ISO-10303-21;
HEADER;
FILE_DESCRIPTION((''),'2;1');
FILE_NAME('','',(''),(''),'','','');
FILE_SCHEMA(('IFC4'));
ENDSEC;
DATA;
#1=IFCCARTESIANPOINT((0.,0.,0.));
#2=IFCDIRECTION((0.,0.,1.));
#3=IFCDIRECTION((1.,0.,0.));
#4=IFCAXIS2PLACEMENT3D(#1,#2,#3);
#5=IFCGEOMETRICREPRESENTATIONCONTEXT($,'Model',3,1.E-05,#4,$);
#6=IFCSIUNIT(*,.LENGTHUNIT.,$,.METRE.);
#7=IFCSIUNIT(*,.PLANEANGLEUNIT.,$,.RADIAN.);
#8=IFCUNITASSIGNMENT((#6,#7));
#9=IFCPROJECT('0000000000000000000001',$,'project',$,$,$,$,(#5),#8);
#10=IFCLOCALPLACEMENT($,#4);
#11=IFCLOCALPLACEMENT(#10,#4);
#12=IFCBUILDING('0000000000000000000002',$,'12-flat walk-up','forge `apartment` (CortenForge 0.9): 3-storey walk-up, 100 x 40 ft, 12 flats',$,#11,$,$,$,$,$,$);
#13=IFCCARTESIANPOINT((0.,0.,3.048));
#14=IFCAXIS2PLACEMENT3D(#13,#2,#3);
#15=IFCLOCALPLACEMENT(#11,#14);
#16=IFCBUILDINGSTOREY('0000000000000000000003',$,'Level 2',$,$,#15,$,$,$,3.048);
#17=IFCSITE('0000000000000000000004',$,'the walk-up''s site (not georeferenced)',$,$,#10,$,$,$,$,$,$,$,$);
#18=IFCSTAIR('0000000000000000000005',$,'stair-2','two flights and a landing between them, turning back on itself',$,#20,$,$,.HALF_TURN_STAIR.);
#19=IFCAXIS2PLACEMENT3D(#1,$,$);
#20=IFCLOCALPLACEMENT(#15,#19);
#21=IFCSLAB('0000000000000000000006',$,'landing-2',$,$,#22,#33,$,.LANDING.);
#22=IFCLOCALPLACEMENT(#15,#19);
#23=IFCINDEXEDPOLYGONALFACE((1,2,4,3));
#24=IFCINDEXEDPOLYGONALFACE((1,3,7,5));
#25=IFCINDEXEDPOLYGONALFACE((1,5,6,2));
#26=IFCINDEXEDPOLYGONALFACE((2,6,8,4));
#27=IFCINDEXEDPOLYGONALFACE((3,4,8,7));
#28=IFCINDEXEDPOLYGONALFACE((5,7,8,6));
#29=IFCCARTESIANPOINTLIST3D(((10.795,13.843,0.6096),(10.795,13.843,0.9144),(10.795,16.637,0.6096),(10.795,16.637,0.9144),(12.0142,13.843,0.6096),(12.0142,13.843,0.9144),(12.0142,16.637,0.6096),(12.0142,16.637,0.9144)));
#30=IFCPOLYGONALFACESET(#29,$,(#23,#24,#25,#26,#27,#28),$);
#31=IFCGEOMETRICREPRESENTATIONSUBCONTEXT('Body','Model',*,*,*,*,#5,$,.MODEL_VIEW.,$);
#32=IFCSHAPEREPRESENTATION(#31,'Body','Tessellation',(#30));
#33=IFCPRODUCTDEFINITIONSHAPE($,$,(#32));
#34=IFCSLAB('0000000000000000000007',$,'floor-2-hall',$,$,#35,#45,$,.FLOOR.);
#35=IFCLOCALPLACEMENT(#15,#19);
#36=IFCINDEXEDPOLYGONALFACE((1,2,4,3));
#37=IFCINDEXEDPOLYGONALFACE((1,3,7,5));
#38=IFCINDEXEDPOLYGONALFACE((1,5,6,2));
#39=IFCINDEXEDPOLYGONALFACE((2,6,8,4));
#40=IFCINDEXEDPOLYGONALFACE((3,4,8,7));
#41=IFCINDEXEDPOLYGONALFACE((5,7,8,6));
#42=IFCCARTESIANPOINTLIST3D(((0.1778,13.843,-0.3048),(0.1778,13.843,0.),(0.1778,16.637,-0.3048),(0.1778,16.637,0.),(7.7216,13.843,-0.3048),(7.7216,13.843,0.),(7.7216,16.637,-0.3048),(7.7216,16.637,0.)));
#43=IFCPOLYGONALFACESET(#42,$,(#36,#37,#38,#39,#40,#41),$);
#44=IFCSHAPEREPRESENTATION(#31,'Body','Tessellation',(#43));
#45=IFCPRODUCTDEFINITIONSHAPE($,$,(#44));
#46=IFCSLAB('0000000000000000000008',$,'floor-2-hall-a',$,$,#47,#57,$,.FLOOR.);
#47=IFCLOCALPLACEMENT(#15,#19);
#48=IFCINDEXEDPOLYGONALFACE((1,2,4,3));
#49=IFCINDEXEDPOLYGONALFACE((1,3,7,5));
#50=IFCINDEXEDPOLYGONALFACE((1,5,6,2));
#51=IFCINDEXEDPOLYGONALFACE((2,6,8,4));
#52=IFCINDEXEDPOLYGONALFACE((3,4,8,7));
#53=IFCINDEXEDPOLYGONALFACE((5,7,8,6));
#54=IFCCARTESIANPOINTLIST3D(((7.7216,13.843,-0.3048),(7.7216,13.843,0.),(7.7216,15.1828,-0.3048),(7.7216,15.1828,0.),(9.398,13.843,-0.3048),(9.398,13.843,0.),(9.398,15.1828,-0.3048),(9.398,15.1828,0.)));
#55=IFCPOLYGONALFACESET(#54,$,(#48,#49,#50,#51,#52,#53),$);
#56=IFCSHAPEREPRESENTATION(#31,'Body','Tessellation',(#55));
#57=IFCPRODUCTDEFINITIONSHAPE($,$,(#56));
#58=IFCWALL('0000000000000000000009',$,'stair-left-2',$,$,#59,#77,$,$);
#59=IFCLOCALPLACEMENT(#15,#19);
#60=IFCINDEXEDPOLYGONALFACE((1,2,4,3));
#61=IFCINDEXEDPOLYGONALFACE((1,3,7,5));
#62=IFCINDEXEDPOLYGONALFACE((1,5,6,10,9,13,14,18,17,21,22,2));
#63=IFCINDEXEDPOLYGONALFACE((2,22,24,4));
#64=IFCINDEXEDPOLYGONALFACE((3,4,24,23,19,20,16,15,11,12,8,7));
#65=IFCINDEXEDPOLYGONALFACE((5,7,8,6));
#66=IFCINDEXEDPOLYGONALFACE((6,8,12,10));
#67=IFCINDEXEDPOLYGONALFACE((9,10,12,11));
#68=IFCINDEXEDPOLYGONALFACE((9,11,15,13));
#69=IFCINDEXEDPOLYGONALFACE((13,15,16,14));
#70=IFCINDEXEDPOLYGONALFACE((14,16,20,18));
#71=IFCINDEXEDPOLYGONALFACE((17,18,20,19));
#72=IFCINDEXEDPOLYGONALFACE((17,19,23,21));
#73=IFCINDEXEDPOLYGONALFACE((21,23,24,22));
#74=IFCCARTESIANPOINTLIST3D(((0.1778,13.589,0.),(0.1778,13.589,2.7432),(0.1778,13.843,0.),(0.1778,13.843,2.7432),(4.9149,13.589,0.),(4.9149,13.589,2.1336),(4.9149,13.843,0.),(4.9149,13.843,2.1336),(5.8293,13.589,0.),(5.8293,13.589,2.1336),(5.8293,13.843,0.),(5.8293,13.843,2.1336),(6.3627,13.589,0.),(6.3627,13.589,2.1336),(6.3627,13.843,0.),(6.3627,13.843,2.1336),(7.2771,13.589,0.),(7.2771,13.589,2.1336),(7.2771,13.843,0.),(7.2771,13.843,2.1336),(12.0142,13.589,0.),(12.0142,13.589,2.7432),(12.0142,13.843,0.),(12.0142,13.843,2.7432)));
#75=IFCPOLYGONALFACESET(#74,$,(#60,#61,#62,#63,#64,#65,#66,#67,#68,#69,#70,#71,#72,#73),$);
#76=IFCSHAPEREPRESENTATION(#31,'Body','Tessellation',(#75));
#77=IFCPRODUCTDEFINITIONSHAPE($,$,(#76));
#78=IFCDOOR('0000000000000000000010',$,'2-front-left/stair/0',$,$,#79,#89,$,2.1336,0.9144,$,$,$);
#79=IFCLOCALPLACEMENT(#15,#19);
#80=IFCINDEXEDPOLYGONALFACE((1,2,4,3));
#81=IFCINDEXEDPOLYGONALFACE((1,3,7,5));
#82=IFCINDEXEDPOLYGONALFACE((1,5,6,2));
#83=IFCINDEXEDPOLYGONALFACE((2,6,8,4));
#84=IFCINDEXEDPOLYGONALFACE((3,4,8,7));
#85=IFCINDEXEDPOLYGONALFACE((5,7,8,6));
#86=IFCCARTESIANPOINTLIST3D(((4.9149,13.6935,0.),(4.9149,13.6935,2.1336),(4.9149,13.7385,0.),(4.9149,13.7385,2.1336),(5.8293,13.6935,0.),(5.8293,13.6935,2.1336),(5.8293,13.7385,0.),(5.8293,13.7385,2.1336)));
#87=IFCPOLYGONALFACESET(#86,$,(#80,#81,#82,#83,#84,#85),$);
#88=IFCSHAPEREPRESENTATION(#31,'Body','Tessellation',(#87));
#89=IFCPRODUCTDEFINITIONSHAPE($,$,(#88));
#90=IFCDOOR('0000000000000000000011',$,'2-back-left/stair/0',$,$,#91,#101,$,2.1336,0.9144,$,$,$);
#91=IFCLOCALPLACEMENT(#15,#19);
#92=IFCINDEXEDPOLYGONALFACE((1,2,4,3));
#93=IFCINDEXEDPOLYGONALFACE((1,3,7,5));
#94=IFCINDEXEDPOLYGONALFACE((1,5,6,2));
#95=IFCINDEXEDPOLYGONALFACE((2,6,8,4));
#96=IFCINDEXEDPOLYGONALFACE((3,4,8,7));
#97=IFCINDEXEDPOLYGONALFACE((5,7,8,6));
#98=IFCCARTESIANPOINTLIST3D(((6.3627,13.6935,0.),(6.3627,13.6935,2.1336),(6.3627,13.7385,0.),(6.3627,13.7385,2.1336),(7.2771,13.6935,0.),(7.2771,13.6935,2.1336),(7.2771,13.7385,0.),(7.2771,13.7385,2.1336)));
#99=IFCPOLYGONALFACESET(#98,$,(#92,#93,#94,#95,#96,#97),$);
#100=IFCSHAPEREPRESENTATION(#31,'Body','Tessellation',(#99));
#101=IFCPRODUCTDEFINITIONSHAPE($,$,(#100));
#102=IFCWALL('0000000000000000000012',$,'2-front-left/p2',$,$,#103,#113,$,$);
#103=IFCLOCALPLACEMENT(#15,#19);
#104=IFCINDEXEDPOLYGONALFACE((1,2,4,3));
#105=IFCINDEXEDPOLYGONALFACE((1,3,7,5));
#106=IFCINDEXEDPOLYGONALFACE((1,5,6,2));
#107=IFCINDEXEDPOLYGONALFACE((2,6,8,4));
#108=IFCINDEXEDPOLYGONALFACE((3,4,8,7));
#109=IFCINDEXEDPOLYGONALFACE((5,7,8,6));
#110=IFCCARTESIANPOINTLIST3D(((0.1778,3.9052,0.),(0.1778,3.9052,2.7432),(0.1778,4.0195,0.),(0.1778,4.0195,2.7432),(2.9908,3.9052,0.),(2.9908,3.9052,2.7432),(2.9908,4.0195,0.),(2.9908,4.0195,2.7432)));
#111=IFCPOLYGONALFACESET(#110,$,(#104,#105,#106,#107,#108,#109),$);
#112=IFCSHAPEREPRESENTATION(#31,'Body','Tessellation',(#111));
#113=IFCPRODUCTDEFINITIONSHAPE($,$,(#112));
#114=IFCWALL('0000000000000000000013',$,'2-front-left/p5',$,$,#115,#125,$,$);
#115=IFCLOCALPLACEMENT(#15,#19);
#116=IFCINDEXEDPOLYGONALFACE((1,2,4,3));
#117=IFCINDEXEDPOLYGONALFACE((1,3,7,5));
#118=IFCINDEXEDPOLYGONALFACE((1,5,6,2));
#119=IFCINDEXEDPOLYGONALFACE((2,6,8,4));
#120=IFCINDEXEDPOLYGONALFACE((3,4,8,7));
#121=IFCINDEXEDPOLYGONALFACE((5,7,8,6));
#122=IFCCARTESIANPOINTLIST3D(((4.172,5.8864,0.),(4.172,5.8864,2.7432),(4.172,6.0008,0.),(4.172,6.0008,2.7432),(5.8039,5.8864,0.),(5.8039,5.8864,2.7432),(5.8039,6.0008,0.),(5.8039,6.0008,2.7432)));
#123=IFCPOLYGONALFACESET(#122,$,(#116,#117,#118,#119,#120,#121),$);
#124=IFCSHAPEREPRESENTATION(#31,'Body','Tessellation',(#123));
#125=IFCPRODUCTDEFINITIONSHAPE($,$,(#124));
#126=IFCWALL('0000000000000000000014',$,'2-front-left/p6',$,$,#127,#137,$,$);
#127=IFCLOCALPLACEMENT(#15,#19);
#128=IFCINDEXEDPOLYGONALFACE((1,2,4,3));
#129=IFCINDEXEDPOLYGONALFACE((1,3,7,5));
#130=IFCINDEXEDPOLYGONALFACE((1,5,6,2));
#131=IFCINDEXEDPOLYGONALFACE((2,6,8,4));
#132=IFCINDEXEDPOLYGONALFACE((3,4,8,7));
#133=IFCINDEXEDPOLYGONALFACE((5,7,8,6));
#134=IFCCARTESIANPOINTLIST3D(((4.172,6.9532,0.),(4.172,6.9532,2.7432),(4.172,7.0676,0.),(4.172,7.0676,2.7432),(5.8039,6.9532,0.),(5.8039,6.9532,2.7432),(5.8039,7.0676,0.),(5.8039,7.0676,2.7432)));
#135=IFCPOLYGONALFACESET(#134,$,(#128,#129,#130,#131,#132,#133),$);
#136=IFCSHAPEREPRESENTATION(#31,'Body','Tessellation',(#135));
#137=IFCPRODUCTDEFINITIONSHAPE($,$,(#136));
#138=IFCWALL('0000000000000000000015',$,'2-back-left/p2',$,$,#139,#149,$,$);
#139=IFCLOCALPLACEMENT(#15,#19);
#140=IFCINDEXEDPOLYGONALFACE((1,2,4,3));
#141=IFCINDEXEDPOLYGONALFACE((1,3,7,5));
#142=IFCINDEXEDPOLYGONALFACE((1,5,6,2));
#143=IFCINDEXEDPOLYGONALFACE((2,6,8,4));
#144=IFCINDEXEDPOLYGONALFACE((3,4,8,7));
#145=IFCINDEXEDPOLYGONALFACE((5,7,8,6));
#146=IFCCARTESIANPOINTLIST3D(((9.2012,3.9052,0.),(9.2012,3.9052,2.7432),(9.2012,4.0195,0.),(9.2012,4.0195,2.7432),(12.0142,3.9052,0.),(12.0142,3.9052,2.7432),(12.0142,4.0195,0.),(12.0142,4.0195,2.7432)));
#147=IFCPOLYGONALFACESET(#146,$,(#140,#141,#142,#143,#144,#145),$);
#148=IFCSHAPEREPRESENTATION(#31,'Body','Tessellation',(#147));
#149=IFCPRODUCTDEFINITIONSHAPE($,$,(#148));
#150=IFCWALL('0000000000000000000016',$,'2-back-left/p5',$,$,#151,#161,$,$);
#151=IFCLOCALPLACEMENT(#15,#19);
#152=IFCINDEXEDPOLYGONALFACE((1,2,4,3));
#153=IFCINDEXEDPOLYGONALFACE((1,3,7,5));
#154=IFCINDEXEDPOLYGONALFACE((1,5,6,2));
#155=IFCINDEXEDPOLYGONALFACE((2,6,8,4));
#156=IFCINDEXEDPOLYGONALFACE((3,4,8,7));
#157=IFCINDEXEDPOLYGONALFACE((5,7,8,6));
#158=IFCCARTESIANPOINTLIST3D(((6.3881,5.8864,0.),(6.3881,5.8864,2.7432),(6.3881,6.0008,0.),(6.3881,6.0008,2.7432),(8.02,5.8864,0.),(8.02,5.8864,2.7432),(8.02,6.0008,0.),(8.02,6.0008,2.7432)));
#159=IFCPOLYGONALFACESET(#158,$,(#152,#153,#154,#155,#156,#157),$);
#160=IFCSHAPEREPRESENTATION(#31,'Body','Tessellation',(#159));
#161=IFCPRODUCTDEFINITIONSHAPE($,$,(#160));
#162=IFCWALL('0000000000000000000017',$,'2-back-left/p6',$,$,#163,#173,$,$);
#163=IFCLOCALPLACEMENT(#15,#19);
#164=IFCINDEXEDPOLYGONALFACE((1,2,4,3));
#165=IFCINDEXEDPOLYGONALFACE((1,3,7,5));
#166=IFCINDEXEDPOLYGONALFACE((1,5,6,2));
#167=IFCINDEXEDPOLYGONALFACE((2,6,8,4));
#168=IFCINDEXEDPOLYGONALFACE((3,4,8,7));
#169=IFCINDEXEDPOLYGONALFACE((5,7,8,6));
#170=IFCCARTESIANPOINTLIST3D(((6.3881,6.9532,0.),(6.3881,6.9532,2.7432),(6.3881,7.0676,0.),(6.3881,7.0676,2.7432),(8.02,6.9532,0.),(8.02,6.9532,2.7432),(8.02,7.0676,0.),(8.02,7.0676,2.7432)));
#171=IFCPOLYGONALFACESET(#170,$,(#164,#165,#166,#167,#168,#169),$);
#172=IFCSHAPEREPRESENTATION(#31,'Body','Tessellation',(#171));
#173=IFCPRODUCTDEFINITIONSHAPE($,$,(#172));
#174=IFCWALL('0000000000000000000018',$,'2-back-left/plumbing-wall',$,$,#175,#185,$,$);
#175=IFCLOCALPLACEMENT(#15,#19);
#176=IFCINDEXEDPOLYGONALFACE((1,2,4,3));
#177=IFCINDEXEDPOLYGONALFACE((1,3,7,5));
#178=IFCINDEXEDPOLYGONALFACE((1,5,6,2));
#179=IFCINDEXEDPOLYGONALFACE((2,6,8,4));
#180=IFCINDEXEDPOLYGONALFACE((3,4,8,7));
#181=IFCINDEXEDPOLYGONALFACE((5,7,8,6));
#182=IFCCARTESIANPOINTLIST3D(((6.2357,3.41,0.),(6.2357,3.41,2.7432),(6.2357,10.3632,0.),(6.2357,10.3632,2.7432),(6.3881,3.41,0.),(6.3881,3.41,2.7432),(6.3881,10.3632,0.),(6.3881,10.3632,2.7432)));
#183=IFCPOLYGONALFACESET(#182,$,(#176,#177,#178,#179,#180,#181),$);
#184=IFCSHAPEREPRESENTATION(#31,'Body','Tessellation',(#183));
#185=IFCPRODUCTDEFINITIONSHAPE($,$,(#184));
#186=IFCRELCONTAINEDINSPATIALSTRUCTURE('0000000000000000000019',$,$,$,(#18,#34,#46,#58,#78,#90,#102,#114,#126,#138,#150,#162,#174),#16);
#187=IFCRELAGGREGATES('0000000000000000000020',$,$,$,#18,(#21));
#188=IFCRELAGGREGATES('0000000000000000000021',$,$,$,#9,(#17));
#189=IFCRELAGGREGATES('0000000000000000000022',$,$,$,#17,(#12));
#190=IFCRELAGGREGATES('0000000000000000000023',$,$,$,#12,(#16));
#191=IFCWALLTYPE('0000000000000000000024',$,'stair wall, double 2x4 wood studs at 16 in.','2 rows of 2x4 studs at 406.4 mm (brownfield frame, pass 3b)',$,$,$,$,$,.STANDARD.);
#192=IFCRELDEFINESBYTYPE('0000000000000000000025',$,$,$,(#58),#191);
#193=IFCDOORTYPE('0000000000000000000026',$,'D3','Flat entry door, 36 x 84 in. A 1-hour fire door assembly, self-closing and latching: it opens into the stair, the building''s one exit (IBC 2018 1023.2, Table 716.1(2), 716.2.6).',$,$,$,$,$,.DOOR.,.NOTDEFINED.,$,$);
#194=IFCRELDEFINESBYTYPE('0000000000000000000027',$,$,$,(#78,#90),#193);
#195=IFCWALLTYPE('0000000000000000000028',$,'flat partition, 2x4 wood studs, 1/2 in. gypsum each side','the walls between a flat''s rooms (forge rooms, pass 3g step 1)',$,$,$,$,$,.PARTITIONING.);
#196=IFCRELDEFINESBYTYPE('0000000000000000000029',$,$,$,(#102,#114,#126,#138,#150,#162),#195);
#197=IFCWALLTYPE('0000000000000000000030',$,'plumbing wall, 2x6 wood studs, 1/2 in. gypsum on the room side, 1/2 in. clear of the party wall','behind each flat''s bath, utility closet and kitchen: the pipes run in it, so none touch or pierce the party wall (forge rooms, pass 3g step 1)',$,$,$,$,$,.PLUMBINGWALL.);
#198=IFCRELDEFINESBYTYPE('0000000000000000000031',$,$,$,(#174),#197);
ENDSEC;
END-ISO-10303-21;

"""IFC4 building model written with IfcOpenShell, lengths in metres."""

from ifc_helpers import new_model, si_unit, frame, frame_2d, origin, origin_with_axes, place, context, subcontext, project, spatial, rectangle, extrude, type_object, element, fill, aggregate, save


model = new_model("IFC4")

# Units and contexts
model_context = context("Model", 3, precision=1e-05, world=origin_with_axes())
body_context = subcontext(model_context, "Body", "Model", "MODEL_VIEW")
ifc_project = project(units=[si_unit("LENGTHUNIT", "METRE"), si_unit("PLANEANGLEUNIT", "RADIAN")], contexts=[model_context])

# Site, building, storey
site_placement = place(None, origin_with_axes())
site = spatial("IfcSite", under=ifc_project, at=site_placement, Name="the walk-up's site (not georeferenced)")
building_placement = place(site_placement, origin_with_axes())
building = spatial("IfcBuilding", under=site, at=building_placement, Name="12-flat walk-up", Description="forge `apartment` (CortenForge 0.9): 3-storey walk-up, 100 x 40 ft, 12 flats")
storey_placement = place(building_placement, frame((0.0, 0.0, 3.048), z_axis=(0.0, 0.0, 1.0), x_axis=(1.0, 0.0, 0.0)))
storey = spatial("IfcBuildingStorey", under=building, at=storey_placement, Name="Level 2", Elevation=3.048)

# Stair, slab
stair_placement = place(storey_placement, frame((0.0, 0.0, -3.048), z_axis=(0.0, 0.0, 1.0), x_axis=(1.0, 0.0, 0.0)))
stair = element("IfcStair", 1, at=stair_placement, inside=storey, Name="stair-2", Description="two flights and a landing between them, turning back on itself", PredefinedType="HALF_TURN_STAIR")
slab_1_placement = place(stair_placement, frame((10.795, 13.843, 3.6576), z_axis=(0.0, 0.0, 1.0), x_axis=(1.0, 0.0, 0.0)))
slab_1 = element("IfcSlab", 2, at=slab_1_placement, Name="landing-2", PredefinedType="LANDING", context=body_context, shape_type="SweptSolid", body=[
    extrude(rectangle(XDim=1.2192, YDim=2.794, at=frame_2d((0.6096, 1.397))), origin(), (0.0, 0.0, 1.0), 0.3048),
])

# Slabs
slab_2_placement = place(storey_placement, frame((0.1778, 13.843, -0.3048), z_axis=(0.0, 0.0, 1.0), x_axis=(1.0, 0.0, 0.0)))
element("IfcSlab", 3, at=slab_2_placement, inside=storey, Name="floor-2-hall", PredefinedType="FLOOR", context=body_context, shape_type="SweptSolid", body=[
    extrude(rectangle(XDim=7.5438, YDim=2.794, at=frame_2d((3.7719, 1.397))), origin(), (0.0, 0.0, 1.0), 0.3048),
])
slab_3_placement = place(storey_placement, frame((7.7216, 13.843, -0.3048), z_axis=(0.0, 0.0, 1.0), x_axis=(1.0, 0.0, 0.0)))
element("IfcSlab", 4, at=slab_3_placement, inside=storey, Name="floor-2-hall-a", PredefinedType="FLOOR", context=body_context, shape_type="SweptSolid", body=[
    extrude(rectangle(XDim=1.6764, YDim=1.3399, at=frame_2d((0.8382, 0.6699))), origin(), (0.0, 0.0, 1.0), 0.3048),
])

# Wall, openings, doors
wall_type_1 = type_object("IfcWallType", Name="stair wall, double 2x4 wood studs at 16 in.", Description="2 rows of 2x4 studs at 406.4 mm (brownfield frame, pass 3b)", PredefinedType="STANDARD")
wall_1_placement = place(storey_placement, frame((0.1778, 13.589, 0.0), z_axis=(0.0, 0.0, 1.0), x_axis=(1.0, 0.0, 0.0)))
wall_1 = element("IfcWall", 5, at=wall_1_placement, inside=storey, type_object=wall_type_1, Name="stair-left-2", context=body_context, shape_type="SweptSolid", body=[
    extrude(rectangle(XDim=11.8364, YDim=0.254, at=frame_2d((5.9182, 0.127))), origin(), (0.0, 0.0, 1.0), 2.7432),
])
opening_1_placement = place(wall_1_placement, frame((4.7371, 0.0, 0.0), z_axis=(0.0, 0.0, 1.0), x_axis=(1.0, 0.0, 0.0)))
opening_1 = element("IfcOpeningElement", 6, at=opening_1_placement, cuts=wall_1, PredefinedType="OPENING", context=body_context, shape_type="SweptSolid", body=[
    extrude(rectangle(XDim=0.9144, YDim=0.254, at=frame_2d((0.4572, 0.127))), origin(), (0.0, 0.0, 1.0), 2.1336),
])
opening_2_placement = place(wall_1_placement, frame((6.1849, 0.0, 0.0), z_axis=(0.0, 0.0, 1.0), x_axis=(1.0, 0.0, 0.0)))
opening_2 = element("IfcOpeningElement", 7, at=opening_2_placement, cuts=wall_1, PredefinedType="OPENING", context=body_context, shape_type="SweptSolid", body=[
    extrude(rectangle(XDim=0.9144, YDim=0.254, at=frame_2d((0.4572, 0.127))), origin(), (0.0, 0.0, 1.0), 2.1336),
])
door_type = type_object("IfcDoorType", Name="D3", Description="Flat entry door, 36 x 84 in. A 1-hour fire door assembly, self-closing and latching: it opens into the stair, the building's one exit (IBC 2018 1023.2, Table 716.1(2), 716.2.6).", OperationType="NOTDEFINED", PredefinedType="DOOR")
door_1_placement = place(opening_1_placement, frame((0.0, 0.1045, 0.0), z_axis=(0.0, 0.0, 1.0), x_axis=(1.0, 0.0, 0.0)))
door_1 = element("IfcDoor", 8, at=door_1_placement, inside=storey, type_object=door_type, Name="2-front-left/stair/0", OverallHeight=2.1336, OverallWidth=0.9144, context=body_context, shape_type="SweptSolid", body=[
    extrude(rectangle(XDim=0.9144, YDim=0.045, at=frame_2d((0.4572, 0.0225))), origin(), (0.0, 0.0, 1.0), 2.1336),
])
fill(opening_1, door_1)
door_2_placement = place(opening_2_placement, frame((0.0, 0.1045, 0.0), z_axis=(0.0, 0.0, 1.0), x_axis=(1.0, 0.0, 0.0)))
door_2 = element("IfcDoor", 9, at=door_2_placement, inside=storey, type_object=door_type, Name="2-back-left/stair/0", OverallHeight=2.1336, OverallWidth=0.9144, context=body_context, shape_type="SweptSolid", body=[
    extrude(rectangle(XDim=0.9144, YDim=0.045, at=frame_2d((0.4572, 0.0225))), origin(), (0.0, 0.0, 1.0), 2.1336),
])
fill(opening_2, door_2)

# Walls
wall_type_2 = type_object("IfcWallType", Name="flat partition, 2x4 wood studs, 1/2 in. gypsum each side", Description="the walls between a flat's rooms (forge rooms, pass 3g step 1)", PredefinedType="PARTITIONING")
wall_2_placement = place(storey_placement, frame((0.1778, 3.9052, 0.0), z_axis=(0.0, 0.0, 1.0), x_axis=(1.0, 0.0, 0.0)))
element("IfcWall", 10, at=wall_2_placement, inside=storey, type_object=wall_type_2, Name="2-front-left/p2", context=body_context, shape_type="SweptSolid", body=[
    extrude(rectangle(XDim=2.8131, YDim=0.1143, at=frame_2d((1.4065, 0.0571))), origin(), (0.0, 0.0, 1.0), 2.7432),
])
for number, where, z_axis, x_axis, name in (
    (11, (4.1719, 5.8864, 0.0), (0.0, 0.0, 1.0), (1.0, 0.0, 0.0), "2-front-left/p5"),
    (12, (4.1719, 6.9532, 0.0), (0.0, 0.0, 1.0), (1.0, 0.0, 0.0), "2-front-left/p6"),
):
    element("IfcWall", number, at=place(storey_placement, frame(where, z_axis=z_axis, x_axis=x_axis)), inside=storey, type_object=wall_type_2, Name=name, context=body_context, shape_type="SweptSolid", body=[
        extrude(rectangle(XDim=1.6319, YDim=0.1143, at=frame_2d((0.816, 0.0572))), origin(), (0.0, 0.0, 1.0), 2.7432),
    ])
wall_3_placement = place(storey_placement, frame((9.2012, 3.9052, 0.0), z_axis=(0.0, 0.0, 1.0), x_axis=(1.0, 0.0, 0.0)))
element("IfcWall", 13, at=wall_3_placement, inside=storey, type_object=wall_type_2, Name="2-back-left/p2", context=body_context, shape_type="SweptSolid", body=[
    extrude(rectangle(XDim=2.8131, YDim=0.1143, at=frame_2d((1.4065, 0.0571))), origin(), (0.0, 0.0, 1.0), 2.7432),
])
for number, where, z_axis, x_axis, name in (
    (14, (6.3881, 5.8864, 0.0), (0.0, 0.0, 1.0), (1.0, 0.0, 0.0), "2-back-left/p5"),
    (15, (6.3881, 6.9532, 0.0), (0.0, 0.0, 1.0), (1.0, 0.0, 0.0), "2-back-left/p6"),
):
    element("IfcWall", number, at=place(storey_placement, frame(where, z_axis=z_axis, x_axis=x_axis)), inside=storey, type_object=wall_type_2, Name=name, context=body_context, shape_type="SweptSolid", body=[
        extrude(rectangle(XDim=1.6319, YDim=0.1143, at=frame_2d((0.816, 0.0572))), origin(), (0.0, 0.0, 1.0), 2.7432),
    ])
wall_type_3 = type_object("IfcWallType", Name="plumbing wall, 2x6 wood studs, 1/2 in. gypsum on the room side, 1/2 in. clear of the party wall", Description="behind each flat's bath, utility closet and kitchen: the pipes run in it, so none touch or pierce the party wall (forge rooms, pass 3g step 1)", PredefinedType="PLUMBINGWALL")
wall_4_placement = place(storey_placement, frame((6.2357, 3.41, 0.0), z_axis=(0.0, 0.0, 1.0), x_axis=(1.0, 0.0, 0.0)))
element("IfcWall", 16, at=wall_4_placement, inside=storey, type_object=wall_type_3, Name="2-back-left/plumbing-wall", context=body_context, shape_type="SweptSolid", body=[
    extrude(rectangle(XDim=0.1524, YDim=6.9533, at=frame_2d((0.0762, 3.4766))), origin(), (0.0, 0.0, 1.0), 2.7432),
])

aggregate(stair, [slab_1])

save(model, "model.ifc")
